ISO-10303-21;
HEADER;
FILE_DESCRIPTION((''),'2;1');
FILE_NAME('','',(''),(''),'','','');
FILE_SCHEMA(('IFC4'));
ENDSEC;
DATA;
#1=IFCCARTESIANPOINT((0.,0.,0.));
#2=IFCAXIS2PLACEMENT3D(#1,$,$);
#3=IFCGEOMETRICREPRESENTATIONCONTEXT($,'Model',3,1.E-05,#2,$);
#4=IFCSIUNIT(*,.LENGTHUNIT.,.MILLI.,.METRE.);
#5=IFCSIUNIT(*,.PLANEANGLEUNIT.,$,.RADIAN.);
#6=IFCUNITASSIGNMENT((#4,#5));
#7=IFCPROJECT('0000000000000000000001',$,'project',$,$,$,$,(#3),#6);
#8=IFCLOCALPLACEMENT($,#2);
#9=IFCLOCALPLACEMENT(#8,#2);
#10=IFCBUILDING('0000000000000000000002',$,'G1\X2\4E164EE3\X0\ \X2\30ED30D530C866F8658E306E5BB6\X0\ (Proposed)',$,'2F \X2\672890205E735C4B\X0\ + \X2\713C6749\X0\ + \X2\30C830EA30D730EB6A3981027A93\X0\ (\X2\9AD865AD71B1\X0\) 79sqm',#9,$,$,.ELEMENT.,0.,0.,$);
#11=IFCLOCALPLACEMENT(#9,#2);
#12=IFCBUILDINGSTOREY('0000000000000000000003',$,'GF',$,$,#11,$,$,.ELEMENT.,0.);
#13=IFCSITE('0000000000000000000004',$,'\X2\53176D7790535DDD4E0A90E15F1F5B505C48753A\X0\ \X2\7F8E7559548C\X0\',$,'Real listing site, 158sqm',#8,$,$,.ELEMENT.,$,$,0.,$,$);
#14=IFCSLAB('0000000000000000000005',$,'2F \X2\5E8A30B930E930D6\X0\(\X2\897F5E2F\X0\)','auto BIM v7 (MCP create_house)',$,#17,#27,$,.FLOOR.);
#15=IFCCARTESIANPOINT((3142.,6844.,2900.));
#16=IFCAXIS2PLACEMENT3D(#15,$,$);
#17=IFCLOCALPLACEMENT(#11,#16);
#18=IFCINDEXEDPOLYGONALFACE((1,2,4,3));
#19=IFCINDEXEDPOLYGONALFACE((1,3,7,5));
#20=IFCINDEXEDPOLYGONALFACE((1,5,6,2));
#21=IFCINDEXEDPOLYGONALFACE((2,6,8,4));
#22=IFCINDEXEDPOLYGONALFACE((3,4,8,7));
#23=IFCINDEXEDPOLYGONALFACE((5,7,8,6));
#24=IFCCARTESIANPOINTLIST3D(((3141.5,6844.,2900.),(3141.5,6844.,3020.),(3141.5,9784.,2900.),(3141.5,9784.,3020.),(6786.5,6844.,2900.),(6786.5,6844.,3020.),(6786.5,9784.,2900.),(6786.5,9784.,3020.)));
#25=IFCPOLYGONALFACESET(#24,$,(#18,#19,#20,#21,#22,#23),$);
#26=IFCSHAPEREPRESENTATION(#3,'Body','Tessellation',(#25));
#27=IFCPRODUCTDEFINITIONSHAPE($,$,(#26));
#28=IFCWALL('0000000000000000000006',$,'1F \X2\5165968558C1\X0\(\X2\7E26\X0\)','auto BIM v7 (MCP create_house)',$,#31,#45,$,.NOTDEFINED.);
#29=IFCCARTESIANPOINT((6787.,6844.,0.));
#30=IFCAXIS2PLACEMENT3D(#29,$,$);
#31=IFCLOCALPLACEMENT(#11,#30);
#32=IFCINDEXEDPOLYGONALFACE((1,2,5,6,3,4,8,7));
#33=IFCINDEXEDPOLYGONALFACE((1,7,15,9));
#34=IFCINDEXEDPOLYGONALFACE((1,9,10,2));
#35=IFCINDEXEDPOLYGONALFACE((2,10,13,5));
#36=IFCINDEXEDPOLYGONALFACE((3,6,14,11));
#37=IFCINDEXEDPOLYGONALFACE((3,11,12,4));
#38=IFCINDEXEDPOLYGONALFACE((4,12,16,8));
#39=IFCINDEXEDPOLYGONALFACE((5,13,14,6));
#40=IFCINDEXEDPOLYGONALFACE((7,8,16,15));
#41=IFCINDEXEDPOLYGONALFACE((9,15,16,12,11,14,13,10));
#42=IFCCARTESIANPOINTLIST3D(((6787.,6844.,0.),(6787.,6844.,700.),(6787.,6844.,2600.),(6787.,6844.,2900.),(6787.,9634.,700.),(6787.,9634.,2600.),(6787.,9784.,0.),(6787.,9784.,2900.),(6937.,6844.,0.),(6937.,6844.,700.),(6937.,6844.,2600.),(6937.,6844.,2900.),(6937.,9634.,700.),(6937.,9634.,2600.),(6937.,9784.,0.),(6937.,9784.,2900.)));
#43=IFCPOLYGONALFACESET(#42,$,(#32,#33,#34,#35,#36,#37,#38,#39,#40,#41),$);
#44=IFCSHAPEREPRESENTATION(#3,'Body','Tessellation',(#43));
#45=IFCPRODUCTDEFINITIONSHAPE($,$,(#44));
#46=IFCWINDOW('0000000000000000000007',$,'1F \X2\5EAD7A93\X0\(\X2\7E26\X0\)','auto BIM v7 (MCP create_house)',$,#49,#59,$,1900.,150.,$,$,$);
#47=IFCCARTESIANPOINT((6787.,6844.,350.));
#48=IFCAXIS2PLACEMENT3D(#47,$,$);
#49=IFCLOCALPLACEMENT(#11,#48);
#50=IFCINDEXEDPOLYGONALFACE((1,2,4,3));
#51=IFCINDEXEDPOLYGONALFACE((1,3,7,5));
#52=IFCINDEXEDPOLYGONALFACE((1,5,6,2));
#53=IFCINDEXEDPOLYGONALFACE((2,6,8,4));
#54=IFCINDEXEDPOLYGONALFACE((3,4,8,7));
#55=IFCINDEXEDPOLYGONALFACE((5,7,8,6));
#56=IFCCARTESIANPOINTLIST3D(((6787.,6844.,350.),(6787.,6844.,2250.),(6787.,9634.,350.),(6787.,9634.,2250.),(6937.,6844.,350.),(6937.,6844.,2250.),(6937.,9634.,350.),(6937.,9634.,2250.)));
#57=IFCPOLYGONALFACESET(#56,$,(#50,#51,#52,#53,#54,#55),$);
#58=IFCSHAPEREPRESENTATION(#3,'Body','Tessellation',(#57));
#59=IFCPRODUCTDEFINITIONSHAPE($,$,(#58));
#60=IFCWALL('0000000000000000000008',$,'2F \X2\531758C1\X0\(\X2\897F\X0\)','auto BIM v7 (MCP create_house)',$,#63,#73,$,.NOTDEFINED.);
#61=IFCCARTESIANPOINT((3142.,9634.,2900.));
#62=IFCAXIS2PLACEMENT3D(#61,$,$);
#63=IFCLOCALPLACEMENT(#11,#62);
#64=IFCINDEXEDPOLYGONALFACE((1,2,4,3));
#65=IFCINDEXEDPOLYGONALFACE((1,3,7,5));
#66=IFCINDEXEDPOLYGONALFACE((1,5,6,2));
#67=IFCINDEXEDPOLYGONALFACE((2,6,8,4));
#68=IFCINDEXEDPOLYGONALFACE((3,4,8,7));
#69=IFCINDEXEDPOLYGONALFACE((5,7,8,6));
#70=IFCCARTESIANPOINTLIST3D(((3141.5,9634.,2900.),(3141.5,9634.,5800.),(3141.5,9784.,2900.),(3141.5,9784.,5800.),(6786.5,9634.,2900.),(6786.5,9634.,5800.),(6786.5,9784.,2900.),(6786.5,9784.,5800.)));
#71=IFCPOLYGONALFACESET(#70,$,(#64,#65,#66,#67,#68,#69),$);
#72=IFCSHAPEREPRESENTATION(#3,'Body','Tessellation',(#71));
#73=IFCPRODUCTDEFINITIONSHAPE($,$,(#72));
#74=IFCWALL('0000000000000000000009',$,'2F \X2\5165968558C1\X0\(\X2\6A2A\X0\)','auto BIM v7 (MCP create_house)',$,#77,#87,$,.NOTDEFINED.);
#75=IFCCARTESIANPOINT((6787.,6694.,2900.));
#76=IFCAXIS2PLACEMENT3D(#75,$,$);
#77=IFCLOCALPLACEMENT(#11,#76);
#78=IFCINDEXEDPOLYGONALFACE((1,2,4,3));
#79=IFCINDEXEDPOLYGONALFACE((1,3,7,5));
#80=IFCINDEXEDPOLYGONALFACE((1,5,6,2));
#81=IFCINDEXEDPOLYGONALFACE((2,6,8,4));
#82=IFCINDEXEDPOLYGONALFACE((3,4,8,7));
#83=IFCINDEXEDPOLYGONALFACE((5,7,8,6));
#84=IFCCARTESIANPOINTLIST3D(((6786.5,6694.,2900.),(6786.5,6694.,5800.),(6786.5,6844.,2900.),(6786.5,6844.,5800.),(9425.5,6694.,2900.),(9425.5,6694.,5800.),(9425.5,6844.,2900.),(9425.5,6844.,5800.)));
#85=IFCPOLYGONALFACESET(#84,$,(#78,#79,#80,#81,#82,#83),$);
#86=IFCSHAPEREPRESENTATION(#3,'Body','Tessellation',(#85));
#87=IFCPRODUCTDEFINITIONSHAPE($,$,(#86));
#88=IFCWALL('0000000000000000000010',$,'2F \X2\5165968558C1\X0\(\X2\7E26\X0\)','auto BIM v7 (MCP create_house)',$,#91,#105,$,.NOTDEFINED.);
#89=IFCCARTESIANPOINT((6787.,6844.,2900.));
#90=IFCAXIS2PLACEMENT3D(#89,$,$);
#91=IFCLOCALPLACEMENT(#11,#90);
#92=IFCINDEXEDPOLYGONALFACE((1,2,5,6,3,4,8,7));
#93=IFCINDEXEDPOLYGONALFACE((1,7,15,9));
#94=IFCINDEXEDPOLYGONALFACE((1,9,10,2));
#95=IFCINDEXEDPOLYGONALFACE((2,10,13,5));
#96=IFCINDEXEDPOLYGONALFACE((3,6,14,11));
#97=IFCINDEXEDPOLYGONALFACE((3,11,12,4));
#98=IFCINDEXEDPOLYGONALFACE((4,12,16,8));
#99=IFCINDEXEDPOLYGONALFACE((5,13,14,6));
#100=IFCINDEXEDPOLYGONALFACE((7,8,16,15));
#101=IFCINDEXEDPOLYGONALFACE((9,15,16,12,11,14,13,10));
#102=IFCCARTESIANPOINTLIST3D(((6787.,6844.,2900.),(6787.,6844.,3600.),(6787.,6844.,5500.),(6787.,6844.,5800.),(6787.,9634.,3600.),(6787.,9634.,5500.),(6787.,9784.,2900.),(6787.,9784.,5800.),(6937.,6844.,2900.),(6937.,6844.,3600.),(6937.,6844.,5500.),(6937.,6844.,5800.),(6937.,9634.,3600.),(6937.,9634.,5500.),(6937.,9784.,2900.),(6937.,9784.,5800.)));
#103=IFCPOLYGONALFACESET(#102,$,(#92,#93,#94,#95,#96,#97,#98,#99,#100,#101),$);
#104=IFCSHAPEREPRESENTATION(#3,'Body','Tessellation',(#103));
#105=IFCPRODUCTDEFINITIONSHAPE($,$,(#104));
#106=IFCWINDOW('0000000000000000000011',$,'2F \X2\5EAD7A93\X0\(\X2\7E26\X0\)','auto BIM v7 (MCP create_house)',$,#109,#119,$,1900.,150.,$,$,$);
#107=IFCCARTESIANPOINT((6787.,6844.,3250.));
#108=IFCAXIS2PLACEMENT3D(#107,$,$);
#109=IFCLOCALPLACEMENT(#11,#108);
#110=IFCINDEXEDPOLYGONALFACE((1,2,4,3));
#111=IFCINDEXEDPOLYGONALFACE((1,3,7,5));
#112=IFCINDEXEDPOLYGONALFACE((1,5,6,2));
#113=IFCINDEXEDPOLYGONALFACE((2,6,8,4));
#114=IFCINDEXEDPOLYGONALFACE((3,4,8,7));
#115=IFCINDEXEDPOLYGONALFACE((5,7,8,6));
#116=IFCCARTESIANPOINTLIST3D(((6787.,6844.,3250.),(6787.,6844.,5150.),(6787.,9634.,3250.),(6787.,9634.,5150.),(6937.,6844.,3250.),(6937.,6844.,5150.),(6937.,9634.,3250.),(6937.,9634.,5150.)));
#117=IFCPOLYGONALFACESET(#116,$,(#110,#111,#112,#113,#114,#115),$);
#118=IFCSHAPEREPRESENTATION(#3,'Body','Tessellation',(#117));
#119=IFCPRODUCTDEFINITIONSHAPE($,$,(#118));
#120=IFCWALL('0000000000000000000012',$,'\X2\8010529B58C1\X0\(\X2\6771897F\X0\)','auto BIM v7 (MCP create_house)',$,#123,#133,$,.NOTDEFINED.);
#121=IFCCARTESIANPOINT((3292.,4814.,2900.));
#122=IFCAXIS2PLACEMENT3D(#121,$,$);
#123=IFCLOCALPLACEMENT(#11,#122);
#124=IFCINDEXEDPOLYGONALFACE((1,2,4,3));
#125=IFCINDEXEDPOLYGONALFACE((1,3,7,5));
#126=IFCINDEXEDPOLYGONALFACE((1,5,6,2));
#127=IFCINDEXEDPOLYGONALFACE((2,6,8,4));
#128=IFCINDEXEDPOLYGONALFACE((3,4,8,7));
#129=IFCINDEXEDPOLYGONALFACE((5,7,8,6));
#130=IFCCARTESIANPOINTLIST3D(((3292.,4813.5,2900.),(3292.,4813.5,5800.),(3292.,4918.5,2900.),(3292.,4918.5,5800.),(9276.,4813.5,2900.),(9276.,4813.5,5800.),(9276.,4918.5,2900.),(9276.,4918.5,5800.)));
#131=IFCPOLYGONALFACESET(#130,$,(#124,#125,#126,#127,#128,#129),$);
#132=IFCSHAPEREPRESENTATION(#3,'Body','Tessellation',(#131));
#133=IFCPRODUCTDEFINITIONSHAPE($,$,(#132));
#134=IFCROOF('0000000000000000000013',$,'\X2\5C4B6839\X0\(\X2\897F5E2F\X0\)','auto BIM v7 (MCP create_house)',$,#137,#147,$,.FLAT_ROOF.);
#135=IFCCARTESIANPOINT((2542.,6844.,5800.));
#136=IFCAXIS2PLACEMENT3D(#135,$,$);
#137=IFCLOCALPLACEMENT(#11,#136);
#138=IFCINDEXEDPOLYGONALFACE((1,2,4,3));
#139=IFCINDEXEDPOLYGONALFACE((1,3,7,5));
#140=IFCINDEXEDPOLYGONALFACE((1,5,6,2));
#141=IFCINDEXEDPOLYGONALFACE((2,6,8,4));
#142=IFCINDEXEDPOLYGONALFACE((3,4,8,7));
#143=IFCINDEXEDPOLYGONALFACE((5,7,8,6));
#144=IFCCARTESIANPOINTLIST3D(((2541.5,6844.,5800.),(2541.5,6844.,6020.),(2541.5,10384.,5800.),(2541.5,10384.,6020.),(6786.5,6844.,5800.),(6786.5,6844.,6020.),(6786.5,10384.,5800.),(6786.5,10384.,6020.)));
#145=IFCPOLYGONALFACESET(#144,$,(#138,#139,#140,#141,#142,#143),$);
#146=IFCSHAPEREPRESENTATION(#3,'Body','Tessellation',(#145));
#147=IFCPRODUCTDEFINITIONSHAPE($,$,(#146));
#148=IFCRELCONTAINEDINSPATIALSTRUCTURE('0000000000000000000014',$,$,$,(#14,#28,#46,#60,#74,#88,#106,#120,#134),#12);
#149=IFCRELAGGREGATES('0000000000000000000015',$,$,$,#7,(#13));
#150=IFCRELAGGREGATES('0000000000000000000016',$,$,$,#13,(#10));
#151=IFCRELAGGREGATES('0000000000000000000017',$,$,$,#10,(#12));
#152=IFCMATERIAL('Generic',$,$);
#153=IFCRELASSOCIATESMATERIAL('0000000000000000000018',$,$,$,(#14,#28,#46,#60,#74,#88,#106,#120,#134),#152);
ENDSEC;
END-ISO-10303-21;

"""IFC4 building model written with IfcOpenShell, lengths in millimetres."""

from ifc_helpers import new_model, si_unit, frame, frame_2d, origin, place, context, project, spatial, rectangle, extrude, material, element, fill, save


model = new_model("IFC4")

# Units and contexts
model_context = context("Model", 3, precision=1e-05, world=origin())
ifc_project = project(units=[si_unit("LENGTHUNIT", "METRE", prefix="MILLI"), si_unit("PLANEANGLEUNIT", "RADIAN")], contexts=[model_context])

# Site, building, storey
site_placement = place(None, origin())
site = spatial("IfcSite", under=ifc_project, at=site_placement, Name="北海道川上郡弟子屈町 美留和", ObjectType="Real listing site, 158sqm", CompositionType="ELEMENT", RefElevation=0.0)
building_placement = place(site_placement, origin())
building = spatial("IfcBuilding", under=site, at=building_placement, Name="G1世代 ロフト書斎の家 (Proposed)", ObjectType="2F 木造平屋 + 焼杉 + トリプル樹脂窓 (高断熱) 79sqm", CompositionType="ELEMENT", ElevationOfRefHeight=0.0, ElevationOfTerrain=0.0)
storey_placement = place(building_placement, origin())
storey = spatial("IfcBuildingStorey", under=building, at=storey_placement, Name="GF", CompositionType="ELEMENT", Elevation=0.0)

# Slab
ifc_material = material(Name="Generic")
slab_1_placement = place(storey_placement, frame((3142.0, 6844.0, 2900.0)))
element("IfcSlab", 1, at=slab_1_placement, inside=storey, material=ifc_material, Name="2F 床スラブ(西帯)", Description="auto BIM v7 (MCP create_house)", PredefinedType="FLOOR", context=model_context, shape_type="SweptSolid", body=[
    extrude(rectangle(XDim=3645.0, YDim=2940.0, at=frame_2d((1822.0, 1470.0))), frame((3142.0, 6844.0, 2900.0)), (0.0, 0.0, 1.0), 120.0),
])

# Wall, opening, window
wall_1_placement = place(storey_placement, frame((6787.0, 6844.0, 0.0)))
wall_1 = element("IfcWall", 2, at=wall_1_placement, inside=storey, material=ifc_material, Name="1F 入隅壁(縦)", Description="auto BIM v7 (MCP create_house)", PredefinedType="NOTDEFINED", context=model_context, shape_type="SweptSolid", body=[
    extrude(rectangle(XDim=150.0, YDim=2940.0, at=frame_2d((75.0, 1470.0))), frame((6787.0, 6844.0, 0.0)), (0.0, 0.0, 1.0), 2900.0),
])
opening_1_placement = place(storey_placement, frame((6787.0, 6844.0, 350.0)))
opening_1 = element("IfcOpeningElement", 3, at=opening_1_placement, cuts=wall_1, PredefinedType="NOTDEFINED", context=model_context, shape_type="SweptSolid", body=[
    extrude(rectangle(XDim=150.0, YDim=2790.0, at=frame_2d((75.0, 1395.0))), frame((6787.0, 6844.0, 350.0)), (0.0, 0.0, 1.0), 1900.0),
])
window_1_placement = place(storey_placement, frame((6787.0, 6844.0, 350.0)))
window_1 = element("IfcWindow", 4, at=window_1_placement, inside=storey, material=ifc_material, Name="1F 庭窓(縦)", Description="auto BIM v7 (MCP create_house)", OverallHeight=1900.0, OverallWidth=150.0, context=model_context, shape_type="SweptSolid", body=[
    extrude(rectangle(XDim=150.0, YDim=2790.0, at=frame_2d((75.0, 1395.0))), frame((6787.0, 6844.0, 350.0)), (0.0, 0.0, 1.0), 1900.0),
])
fill(opening_1, window_1)

# Walls
wall_2_placement = place(storey_placement, frame((3142.0, 9634.0, 2900.0)))
element("IfcWall", 5, at=wall_2_placement, inside=storey, material=ifc_material, Name="2F 北壁(西)", Description="auto BIM v7 (MCP create_house)", PredefinedType="NOTDEFINED", context=model_context, shape_type="SweptSolid", body=[
    extrude(rectangle(XDim=3645.0, YDim=150.0, at=frame_2d((1822.0, 75.0))), frame((3142.0, 9634.0, 2900.0)), (0.0, 0.0, 1.0), 2900.0),
])
wall_3_placement = place(storey_placement, frame((6787.0, 6694.0, 2900.0)))
element("IfcWall", 6, at=wall_3_placement, inside=storey, material=ifc_material, Name="2F 入隅壁(横)", Description="auto BIM v7 (MCP create_house)", PredefinedType="NOTDEFINED", context=model_context, shape_type="SweptSolid", body=[
    extrude(rectangle(XDim=2639.0, YDim=150.0, at=frame_2d((1319.0, 75.0))), frame((6787.0, 6694.0, 2900.0)), (0.0, 0.0, 1.0), 2900.0),
])

# Wall, opening, window
wall_4_placement = place(storey_placement, frame((6787.0, 6844.0, 2900.0)))
wall_4 = element("IfcWall", 7, at=wall_4_placement, inside=storey, material=ifc_material, Name="2F 入隅壁(縦)", Description="auto BIM v7 (MCP create_house)", PredefinedType="NOTDEFINED", context=model_context, shape_type="SweptSolid", body=[
    extrude(rectangle(XDim=150.0, YDim=2940.0, at=frame_2d((75.0, 1470.0))), frame((6787.0, 6844.0, 2900.0)), (0.0, 0.0, 1.0), 2900.0),
])
opening_2_placement = place(storey_placement, frame((6787.0, 6844.0, 3250.0)))
opening_2 = element("IfcOpeningElement", 8, at=opening_2_placement, cuts=wall_4, PredefinedType="NOTDEFINED", context=model_context, shape_type="SweptSolid", body=[
    extrude(rectangle(XDim=150.0, YDim=2790.0, at=frame_2d((75.0, 1395.0))), frame((6787.0, 6844.0, 3250.0)), (0.0, 0.0, 1.0), 1900.0),
])
window_2_placement = place(storey_placement, frame((6787.0, 6844.0, 3250.0)))
window_2 = element("IfcWindow", 9, at=window_2_placement, inside=storey, material=ifc_material, Name="2F 庭窓(縦)", Description="auto BIM v7 (MCP create_house)", OverallHeight=1900.0, OverallWidth=150.0, context=model_context, shape_type="SweptSolid", body=[
    extrude(rectangle(XDim=150.0, YDim=2790.0, at=frame_2d((75.0, 1395.0))), frame((6787.0, 6844.0, 3250.0)), (0.0, 0.0, 1.0), 1900.0),
])
fill(opening_2, window_2)

# Wall
wall_5_placement = place(storey_placement, frame((3292.0, 4814.0, 2900.0)))
element("IfcWall", 10, at=wall_5_placement, inside=storey, material=ifc_material, Name="耐力壁(東西)", Description="auto BIM v7 (MCP create_house)", PredefinedType="NOTDEFINED", context=model_context, shape_type="SweptSolid", body=[
    extrude(rectangle(XDim=5984.0, YDim=105.0, at=frame_2d((2992.0, 52.0))), frame((3292.0, 4814.0, 2900.0)), (0.0, 0.0, 1.0), 2900.0),
])

# Roof
for number, where, name in (
    (11, (2542.0, 6844.0, 5800.0), "屋根(西帯)"),
):
    element("IfcRoof", number, at=place(storey_placement, frame(where)), inside=storey, material=ifc_material, Name=name, Description="auto BIM v7 (MCP create_house)", PredefinedType="FLAT_ROOF", context=model_context, shape_type="SweptSolid", body=[
        extrude(rectangle(XDim=4245.0, YDim=3540.0, at=frame_2d((2122.0, 1770.0))), frame((2542.0, 6844.0, 5800.0)), (0.0, 0.0, 1.0), 220.0),
    ])

save(model, "model.ifc")
